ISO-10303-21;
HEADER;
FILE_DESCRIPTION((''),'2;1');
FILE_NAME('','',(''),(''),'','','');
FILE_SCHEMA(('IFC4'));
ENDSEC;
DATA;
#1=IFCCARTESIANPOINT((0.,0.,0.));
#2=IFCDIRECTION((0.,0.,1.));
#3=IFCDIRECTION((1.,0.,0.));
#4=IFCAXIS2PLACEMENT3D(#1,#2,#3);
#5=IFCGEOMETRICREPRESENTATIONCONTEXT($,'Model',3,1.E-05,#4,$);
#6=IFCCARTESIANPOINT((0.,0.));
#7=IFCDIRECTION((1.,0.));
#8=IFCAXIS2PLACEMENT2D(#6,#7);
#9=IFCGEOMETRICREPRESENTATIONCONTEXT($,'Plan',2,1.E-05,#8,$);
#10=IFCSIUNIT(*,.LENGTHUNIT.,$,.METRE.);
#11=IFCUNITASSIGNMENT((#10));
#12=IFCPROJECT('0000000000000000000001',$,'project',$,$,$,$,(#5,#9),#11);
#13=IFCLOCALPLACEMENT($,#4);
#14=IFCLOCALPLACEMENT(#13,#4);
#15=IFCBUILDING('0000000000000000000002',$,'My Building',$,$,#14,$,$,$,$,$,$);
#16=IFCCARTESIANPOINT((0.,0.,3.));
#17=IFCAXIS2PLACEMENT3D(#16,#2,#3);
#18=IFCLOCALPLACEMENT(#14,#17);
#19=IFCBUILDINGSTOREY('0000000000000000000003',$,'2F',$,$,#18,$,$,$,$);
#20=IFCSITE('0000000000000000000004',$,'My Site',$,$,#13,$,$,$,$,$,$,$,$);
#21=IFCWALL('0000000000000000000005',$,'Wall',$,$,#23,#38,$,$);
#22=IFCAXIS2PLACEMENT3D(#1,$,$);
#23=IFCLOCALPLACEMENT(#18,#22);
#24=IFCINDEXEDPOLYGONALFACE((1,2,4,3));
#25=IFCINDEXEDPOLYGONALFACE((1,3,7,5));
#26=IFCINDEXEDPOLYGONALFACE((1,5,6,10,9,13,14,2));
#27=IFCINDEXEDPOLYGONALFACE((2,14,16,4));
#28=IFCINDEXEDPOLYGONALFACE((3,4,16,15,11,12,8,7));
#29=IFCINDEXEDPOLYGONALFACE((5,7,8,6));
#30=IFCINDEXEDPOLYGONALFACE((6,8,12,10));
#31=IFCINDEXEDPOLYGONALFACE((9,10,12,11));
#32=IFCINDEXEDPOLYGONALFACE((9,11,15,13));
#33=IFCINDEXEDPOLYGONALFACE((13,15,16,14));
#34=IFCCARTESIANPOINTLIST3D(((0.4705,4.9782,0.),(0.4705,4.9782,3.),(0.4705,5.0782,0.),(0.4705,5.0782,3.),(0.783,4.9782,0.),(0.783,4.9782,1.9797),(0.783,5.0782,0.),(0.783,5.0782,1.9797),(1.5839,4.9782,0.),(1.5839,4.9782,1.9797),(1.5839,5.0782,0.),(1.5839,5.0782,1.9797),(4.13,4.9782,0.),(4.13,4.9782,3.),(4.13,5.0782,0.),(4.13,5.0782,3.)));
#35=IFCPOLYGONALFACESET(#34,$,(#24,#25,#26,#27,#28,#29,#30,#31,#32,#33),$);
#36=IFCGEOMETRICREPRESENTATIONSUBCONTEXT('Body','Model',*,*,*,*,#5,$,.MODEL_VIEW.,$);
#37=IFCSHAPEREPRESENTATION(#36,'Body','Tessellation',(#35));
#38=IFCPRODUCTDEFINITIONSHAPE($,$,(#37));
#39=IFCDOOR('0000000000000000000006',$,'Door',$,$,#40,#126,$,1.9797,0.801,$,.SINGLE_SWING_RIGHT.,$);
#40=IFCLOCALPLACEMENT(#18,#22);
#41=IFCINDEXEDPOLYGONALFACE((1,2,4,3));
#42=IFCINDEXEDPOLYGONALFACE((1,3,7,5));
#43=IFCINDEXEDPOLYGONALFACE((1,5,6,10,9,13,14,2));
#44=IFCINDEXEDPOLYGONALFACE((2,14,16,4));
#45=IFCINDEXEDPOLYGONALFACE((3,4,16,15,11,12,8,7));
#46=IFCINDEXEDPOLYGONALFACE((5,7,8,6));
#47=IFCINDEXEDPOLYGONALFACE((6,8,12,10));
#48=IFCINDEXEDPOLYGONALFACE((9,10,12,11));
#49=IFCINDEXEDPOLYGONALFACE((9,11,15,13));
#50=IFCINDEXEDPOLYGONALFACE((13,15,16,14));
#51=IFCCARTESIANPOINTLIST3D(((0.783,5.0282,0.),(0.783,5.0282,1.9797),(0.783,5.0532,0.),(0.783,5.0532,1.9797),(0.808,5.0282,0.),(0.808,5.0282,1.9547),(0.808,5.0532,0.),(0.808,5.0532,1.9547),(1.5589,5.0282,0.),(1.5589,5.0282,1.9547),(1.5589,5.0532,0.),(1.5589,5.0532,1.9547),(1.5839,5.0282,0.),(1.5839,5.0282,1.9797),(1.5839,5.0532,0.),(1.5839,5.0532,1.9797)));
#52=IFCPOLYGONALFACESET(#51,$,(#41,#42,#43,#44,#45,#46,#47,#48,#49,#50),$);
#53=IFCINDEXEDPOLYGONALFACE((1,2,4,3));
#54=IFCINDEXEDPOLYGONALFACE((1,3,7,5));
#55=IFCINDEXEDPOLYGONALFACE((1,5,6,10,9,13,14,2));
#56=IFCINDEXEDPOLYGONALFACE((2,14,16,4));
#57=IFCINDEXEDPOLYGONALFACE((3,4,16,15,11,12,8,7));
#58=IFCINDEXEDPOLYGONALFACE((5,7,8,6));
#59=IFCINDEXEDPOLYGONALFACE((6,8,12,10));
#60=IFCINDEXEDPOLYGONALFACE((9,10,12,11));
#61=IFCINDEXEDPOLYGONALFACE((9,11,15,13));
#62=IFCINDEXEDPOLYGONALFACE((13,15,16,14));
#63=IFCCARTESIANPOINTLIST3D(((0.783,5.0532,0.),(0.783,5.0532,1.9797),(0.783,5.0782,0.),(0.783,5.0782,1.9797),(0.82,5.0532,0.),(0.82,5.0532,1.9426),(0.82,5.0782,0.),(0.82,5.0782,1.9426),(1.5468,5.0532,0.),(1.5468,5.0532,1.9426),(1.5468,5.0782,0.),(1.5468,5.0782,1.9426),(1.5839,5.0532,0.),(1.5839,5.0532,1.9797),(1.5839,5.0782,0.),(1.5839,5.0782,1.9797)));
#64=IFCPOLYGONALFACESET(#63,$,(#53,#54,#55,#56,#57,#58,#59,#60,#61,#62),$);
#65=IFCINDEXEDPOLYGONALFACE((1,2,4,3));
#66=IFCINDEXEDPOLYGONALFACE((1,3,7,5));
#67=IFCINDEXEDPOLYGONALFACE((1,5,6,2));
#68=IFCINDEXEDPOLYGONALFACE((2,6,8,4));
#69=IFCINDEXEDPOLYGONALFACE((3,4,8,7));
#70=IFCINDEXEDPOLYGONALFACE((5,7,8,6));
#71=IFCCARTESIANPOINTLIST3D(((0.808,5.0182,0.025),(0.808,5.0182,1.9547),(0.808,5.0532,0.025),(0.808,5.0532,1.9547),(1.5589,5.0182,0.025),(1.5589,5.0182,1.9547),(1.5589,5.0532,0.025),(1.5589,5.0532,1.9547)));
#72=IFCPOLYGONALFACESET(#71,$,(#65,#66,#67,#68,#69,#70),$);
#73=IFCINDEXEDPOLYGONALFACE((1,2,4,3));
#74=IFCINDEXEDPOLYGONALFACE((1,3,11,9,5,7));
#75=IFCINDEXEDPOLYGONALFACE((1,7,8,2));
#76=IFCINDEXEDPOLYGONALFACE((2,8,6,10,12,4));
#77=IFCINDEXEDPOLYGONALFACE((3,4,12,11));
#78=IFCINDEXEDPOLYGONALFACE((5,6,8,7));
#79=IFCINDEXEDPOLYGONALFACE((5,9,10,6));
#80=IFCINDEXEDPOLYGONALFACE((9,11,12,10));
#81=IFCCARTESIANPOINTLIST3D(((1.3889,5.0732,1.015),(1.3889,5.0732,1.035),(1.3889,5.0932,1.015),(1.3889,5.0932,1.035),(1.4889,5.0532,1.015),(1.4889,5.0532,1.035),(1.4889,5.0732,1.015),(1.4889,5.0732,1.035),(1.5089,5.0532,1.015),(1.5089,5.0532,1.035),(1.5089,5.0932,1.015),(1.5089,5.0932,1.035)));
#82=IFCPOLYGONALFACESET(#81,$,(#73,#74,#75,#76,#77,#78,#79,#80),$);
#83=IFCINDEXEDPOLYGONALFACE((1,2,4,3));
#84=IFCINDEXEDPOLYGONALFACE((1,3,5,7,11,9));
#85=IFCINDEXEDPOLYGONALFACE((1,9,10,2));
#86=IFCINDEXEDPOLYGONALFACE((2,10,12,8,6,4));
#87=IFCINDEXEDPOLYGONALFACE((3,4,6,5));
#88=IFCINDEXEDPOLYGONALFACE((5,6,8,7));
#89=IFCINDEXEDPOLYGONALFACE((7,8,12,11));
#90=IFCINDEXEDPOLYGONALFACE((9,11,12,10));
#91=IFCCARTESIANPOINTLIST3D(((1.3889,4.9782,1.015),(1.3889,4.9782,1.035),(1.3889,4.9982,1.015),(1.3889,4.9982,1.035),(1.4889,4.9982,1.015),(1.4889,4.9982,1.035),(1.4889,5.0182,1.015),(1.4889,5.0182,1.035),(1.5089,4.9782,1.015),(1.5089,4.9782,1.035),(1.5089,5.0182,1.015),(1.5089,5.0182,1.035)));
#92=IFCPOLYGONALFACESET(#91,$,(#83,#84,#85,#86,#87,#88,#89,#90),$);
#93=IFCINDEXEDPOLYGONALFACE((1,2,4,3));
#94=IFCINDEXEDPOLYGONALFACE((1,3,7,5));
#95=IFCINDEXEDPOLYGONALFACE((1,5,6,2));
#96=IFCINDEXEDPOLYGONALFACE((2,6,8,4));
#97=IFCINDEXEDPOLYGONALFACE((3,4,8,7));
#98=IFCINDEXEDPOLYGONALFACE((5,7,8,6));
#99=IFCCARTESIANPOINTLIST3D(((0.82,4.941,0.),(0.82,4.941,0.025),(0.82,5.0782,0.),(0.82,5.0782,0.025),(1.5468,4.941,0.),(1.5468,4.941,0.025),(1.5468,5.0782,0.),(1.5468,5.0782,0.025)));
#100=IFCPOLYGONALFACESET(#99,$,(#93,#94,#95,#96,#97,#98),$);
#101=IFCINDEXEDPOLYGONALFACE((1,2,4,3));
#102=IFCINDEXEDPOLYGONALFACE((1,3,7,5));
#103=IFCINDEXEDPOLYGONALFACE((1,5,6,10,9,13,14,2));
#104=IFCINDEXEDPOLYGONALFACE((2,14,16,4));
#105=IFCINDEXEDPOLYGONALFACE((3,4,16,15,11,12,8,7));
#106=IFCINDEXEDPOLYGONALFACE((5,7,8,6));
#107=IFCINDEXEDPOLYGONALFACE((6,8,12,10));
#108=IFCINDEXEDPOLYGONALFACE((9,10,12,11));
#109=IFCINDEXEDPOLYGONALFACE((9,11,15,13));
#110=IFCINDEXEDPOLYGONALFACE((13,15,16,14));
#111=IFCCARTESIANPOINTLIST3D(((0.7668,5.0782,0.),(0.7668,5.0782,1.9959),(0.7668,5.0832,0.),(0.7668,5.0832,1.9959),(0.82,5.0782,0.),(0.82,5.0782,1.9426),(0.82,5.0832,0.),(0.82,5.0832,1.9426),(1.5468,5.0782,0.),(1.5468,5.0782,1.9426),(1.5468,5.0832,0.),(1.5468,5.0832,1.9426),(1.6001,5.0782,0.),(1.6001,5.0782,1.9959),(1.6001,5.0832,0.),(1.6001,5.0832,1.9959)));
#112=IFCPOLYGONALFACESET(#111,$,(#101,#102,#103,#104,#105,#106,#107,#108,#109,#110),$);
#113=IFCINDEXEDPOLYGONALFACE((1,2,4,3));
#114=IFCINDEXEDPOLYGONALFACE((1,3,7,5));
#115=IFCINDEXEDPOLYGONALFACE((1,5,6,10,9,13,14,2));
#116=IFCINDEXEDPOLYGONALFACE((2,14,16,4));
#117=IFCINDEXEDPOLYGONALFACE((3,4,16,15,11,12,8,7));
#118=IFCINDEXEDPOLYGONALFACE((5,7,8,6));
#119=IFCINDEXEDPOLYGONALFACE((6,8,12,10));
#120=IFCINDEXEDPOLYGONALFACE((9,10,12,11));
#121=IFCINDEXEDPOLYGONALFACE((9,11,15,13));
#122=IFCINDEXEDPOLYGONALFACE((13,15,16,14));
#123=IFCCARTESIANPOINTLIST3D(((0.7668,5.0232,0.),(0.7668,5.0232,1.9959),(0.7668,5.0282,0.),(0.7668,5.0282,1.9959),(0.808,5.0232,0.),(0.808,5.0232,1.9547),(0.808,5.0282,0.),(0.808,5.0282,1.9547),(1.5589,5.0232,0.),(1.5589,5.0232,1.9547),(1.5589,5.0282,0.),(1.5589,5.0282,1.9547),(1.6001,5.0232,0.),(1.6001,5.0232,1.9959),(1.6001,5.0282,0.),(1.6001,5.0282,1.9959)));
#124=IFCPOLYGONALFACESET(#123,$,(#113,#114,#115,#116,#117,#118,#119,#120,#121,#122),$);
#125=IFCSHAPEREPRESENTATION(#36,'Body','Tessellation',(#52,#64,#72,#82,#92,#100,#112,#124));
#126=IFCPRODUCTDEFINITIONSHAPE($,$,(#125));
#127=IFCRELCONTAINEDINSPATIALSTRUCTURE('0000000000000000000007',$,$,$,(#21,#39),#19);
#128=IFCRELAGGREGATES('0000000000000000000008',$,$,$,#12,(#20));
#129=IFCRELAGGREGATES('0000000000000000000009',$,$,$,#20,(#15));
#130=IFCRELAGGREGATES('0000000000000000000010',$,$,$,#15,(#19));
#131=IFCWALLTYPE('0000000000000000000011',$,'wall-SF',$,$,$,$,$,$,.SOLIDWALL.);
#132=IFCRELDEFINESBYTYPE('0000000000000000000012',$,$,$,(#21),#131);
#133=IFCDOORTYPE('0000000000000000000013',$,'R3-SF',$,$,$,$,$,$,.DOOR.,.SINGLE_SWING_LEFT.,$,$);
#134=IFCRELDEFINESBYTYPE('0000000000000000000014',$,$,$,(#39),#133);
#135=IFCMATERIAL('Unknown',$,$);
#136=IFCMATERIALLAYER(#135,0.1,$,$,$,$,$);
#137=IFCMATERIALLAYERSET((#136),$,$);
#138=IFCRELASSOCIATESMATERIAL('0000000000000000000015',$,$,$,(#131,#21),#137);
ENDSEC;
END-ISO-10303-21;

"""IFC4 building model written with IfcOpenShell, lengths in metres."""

from ifc_helpers import new_model, entity, si_unit, frame, origin_with_axes, origin_2d_with_axis, place, context, subcontext, project, spatial, line, indexed_curve, outline, extrude, shape, source, transform, mapped, material, layer, layer_set, layer_usage, type_object, type_shapes, element, fill, save


model = new_model("IFC4")

# Units and contexts
model_context = context("Model", 3, precision=1e-05, world=origin_with_axes())
plan_context = context("Plan", 2, precision=1e-05, world=origin_2d_with_axis())
body_context_1 = subcontext(model_context, "Body", "Model", "MODEL_VIEW")
body_context_2 = subcontext(plan_context, "Body", "Plan", "PLAN_VIEW")
ifc_project = project(units=[si_unit("LENGTHUNIT", "METRE")], contexts=[model_context, plan_context])

# Site, building, storey
site_placement = place(None, origin_with_axes())
site = spatial("IfcSite", under=ifc_project, at=site_placement, Name="My Site")
building_placement = place(site_placement, origin_with_axes())
building = spatial("IfcBuilding", under=site, at=building_placement, Name="My Building")
storey_placement = place(building_placement, frame((0.0, 0.0, 3.0), z_axis=(0.0, 0.0, 1.0), x_axis=(1.0, 0.0, 0.0)))
storey = spatial("IfcBuildingStorey", under=building, at=storey_placement, Name="2F")

# Shared definitions
ifc_material = material(Name="Unknown")

# Shared definitions
ifc_layer_1 = layer(ifc_material, 0.1)
ifc_layer_set_1 = layer_set([ifc_layer_1])
wall_type = type_object("IfcWallType", Name="wall-SF", PredefinedType="SOLIDWALL", material=ifc_layer_set_1)

# Wall, opening, door
ifc_layer_usage_1 = layer_usage(ifc_layer_set_1, "AXIS2", "POSITIVE", 0.0)
wall_1_placement = place(storey_placement, frame((0.4705, 4.9782, 0.0), z_axis=(0.0, 0.0, 1.0), x_axis=(1.0, 0.0, 0.0)))
wall_1 = element("IfcWall", 1, at=wall_1_placement, inside=storey, type_object=wall_type, material=ifc_layer_usage_1, Name="Wall", context=body_context_1, shape_type="SweptSolid", body=[
    extrude(outline(indexed_curve([(0.0, 0.0), (0.0, 0.1), (3.6595, 0.1), (3.6595, 0.0)], segments=[line(1, 2, 3, 4, 1)])), origin_with_axes(), (0.0, 0.0, 1.0), 3.0),
])
shared_shape_1 = source(origin_with_axes(), body_context_1, "Body", "SweptSolid", [
    extrude(outline(indexed_curve([(0.0, 0.0), (0.801, 0.0), (0.801, 1.9797), (0.0, 1.9797)], segments=[line(1, 2, 3, 4, 1)])), frame((0.0, -0.6, 0.0), z_axis=(0.0, -1.0, 0.0), x_axis=(1.0, 0.0, 0.0)), (0.0, 0.0, -1.0), 1.2),
])
opening_1_placement = place(wall_1_placement, frame((1.1134, 0.1, 0.0), z_axis=(0.0, 0.0, 1.0), x_axis=(-1.0, 0.0, 0.0)))
opening_1 = element("IfcOpeningElement", 2, at=opening_1_placement, cuts=wall_1, PredefinedType="OPENING", context=body_context_1, shape_type="MappedRepresentation", body=[
    mapped(shared_shape_1, transform((0.0, 0.0, 0.0), x_axis=(1.0, 0.0, 0.0), y_axis=(0.0, 1.0, 0.0), z_axis=(0.0, 0.0, 1.0), scale=1.0)),
])
door_type_1 = type_object("IfcDoorType", Name="R3-SF", OperationType="SINGLE_SWING_LEFT", PredefinedType="DOOR")
shared_shape_2 = source(origin_with_axes(), body_context_1, "Body", "SweptSolid", [
    extrude(outline(indexed_curve([(0.0, 0.0), (0.0, 1.9797), (0.801, 1.9797), (0.801, 0.0), (0.776, 0.0), (0.776, 1.9547), (0.025, 1.9547), (0.025, 0.0)], segments=[line(1, 2, 3, 4, 5, 6, 7, 8, 1)])), frame((0.0, 0.025, 0.0), z_axis=(0.0, -1.0, 0.0), x_axis=(1.0, 0.0, 0.0)), (0.0, 0.0, -1.0), 0.025),
    extrude(outline(indexed_curve([(0.0, 0.0), (0.0, 1.9797), (0.801, 1.9797), (0.801, 0.0), (0.7639, 0.0), (0.7639, 1.9426), (0.0371, 1.9426), (0.0371, 0.0)], segments=[line(1, 2, 3, 4, 5, 6, 7, 8, 1)])), frame((0.0, 0.0, 0.0), z_axis=(0.0, -1.0, 0.0), x_axis=(1.0, 0.0, 0.0)), (0.0, 0.0, -1.0), 0.025),
    extrude(outline(indexed_curve([(0.0, 0.0), (0.751, 0.0), (0.751, 0.035), (0.0, 0.035)], segments=[line(1, 2, 3, 4, 1)])), frame((0.025, 0.025, 0.025), z_axis=(0.0, 0.0, 1.0), x_axis=(1.0, 0.0, 0.0)), (0.0, 0.0, 1.0), 1.9297),
    extrude(outline(indexed_curve([(0.0, 0.0), (0.0, -0.04), (0.12, -0.04), (0.12, -0.02), (0.02, -0.02), (0.02, 0.0)], segments=[line(1, 2, 3, 4, 5, 6, 1)])), frame((0.075, 0.025, 1.015), z_axis=(0.0, 0.0, 1.0), x_axis=(1.0, 0.0, 0.0)), (0.0, 0.0, 1.0), 0.02),
    extrude(outline(indexed_curve([(0.0, 0.0), (0.0, 0.04), (0.12, 0.04), (0.12, 0.02), (0.02, 0.02), (0.02, 0.0)], segments=[line(1, 2, 3, 4, 5, 6, 1)])), frame((0.075, 0.06, 1.015), z_axis=(0.0, 0.0, 1.0), x_axis=(1.0, 0.0, 0.0)), (0.0, 0.0, 1.0), 0.02),
    extrude(outline(indexed_curve([(0.0, 0.0), (0.7268, 0.0), (0.7268, 0.1372), (0.0, 0.1372)], segments=[line(1, 2, 3, 4, 1)])), frame((0.0371, 0.0, 0.0), z_axis=(0.0, 0.0, 1.0), x_axis=(1.0, 0.0, 0.0)), (0.0, 0.0, 1.0), 0.025),
    extrude(outline(indexed_curve([(0.0, 0.0), (0.0, 1.9959), (0.8333, 1.9959), (0.8333, 0.0), (0.78, 0.0), (0.78, 1.9426), (0.0532, 1.9426), (0.0532, 0.0)], segments=[line(1, 2, 3, 4, 5, 6, 7, 8, 1)])), frame((-0.0162, -0.005, 0.0), z_axis=(0.0, -1.0, 0.0), x_axis=(1.0, 0.0, 0.0)), (0.0, 0.0, -1.0), 0.005),
    extrude(outline(indexed_curve([(0.0, 0.0), (0.0, 1.9959), (0.8333, 1.9959), (0.8333, 0.0), (0.7921, 0.0), (0.7921, 1.9547), (0.0412, 1.9547), (0.0412, 0.0)], segments=[line(1, 2, 3, 4, 5, 6, 7, 8, 1)])), frame((-0.0162, 0.05, 0.0), z_axis=(0.0, -1.0, 0.0), x_axis=(1.0, 0.0, 0.0)), (0.0, 0.0, -1.0), 0.005),
])
shared_shape_3 = source(origin_with_axes(), body_context_2, "Body", "Curve2D", [
    entity("IfcIndexedPolyCurve", entity("IfcCartesianPointList2D", [[0.0, 0.0], [0.0, 0.05], [0.025, 0.05], [0.025, 0.025], [0.0371, 0.025], [0.0371, 0.0]]), [entity("IfcLineIndex", [1, 2, 3, 4, 5, 6, 1])]),
    entity("IfcIndexedPolyCurve", entity("IfcCartesianPointList2D", [[0.801, 0.0], [0.801, 0.05], [0.776, 0.05], [0.776, 0.025], [0.7639, 0.025], [0.7639, 0.0]]), [entity("IfcLineIndex", [1, 2, 3, 4, 5, 6, 1])]),
    entity("IfcTrimmedCurve", entity("IfcEllipse", entity("IfcAxis2Placement2D", entity("IfcCartesianPoint", [0.741, 0.05]), entity("IfcDirection", [1.0, 0.0])), 0.716, 0.751), [entity("IfcCartesianPoint", [0.741, 0.801])], [entity("IfcCartesianPoint", [0.025, 0.05])], True, "CARTESIAN"),
    entity("IfcIndexedPolyCurve", entity("IfcCartesianPointList2D", [[0.776, 0.05], [0.741, 0.05], [0.741, 0.801], [0.776, 0.801]]), [entity("IfcLineIndex", [1, 2, 3, 4, 1])]),
])
type_shapes(door_type_1, [shared_shape_2, shared_shape_3])
door_1_placement = place(opening_1_placement, frame((0.0, 0.0, 0.0), z_axis=(0.0, 0.0, 1.0), x_axis=(1.0, 0.0, 0.0)))
door_1 = element("IfcDoor", 3, at=door_1_placement, inside=storey, type_object=door_type_1, Name="Door", OperationType="SINGLE_SWING_RIGHT", OverallHeight=1.9797, OverallWidth=0.801, shapes=[
    shape(body_context_1, "Body", "MappedRepresentation", [mapped(shared_shape_2, transform((0.0, 0.0, 0.0), x_axis=(1.0, 0.0, 0.0), y_axis=(0.0, 1.0, 0.0), z_axis=(0.0, 0.0, 1.0), scale=1.0))]),
    shape(body_context_2, "Body", "MappedRepresentation", [mapped(shared_shape_3, transform((0.0, 0.0, 0.0), x_axis=(1.0, 0.0, 0.0), y_axis=(0.0, 1.0, 0.0), z_axis=(0.0, 0.0, 1.0), scale=1.0))]),
])
fill(opening_1, door_1)

save(model, "model.ifc")
